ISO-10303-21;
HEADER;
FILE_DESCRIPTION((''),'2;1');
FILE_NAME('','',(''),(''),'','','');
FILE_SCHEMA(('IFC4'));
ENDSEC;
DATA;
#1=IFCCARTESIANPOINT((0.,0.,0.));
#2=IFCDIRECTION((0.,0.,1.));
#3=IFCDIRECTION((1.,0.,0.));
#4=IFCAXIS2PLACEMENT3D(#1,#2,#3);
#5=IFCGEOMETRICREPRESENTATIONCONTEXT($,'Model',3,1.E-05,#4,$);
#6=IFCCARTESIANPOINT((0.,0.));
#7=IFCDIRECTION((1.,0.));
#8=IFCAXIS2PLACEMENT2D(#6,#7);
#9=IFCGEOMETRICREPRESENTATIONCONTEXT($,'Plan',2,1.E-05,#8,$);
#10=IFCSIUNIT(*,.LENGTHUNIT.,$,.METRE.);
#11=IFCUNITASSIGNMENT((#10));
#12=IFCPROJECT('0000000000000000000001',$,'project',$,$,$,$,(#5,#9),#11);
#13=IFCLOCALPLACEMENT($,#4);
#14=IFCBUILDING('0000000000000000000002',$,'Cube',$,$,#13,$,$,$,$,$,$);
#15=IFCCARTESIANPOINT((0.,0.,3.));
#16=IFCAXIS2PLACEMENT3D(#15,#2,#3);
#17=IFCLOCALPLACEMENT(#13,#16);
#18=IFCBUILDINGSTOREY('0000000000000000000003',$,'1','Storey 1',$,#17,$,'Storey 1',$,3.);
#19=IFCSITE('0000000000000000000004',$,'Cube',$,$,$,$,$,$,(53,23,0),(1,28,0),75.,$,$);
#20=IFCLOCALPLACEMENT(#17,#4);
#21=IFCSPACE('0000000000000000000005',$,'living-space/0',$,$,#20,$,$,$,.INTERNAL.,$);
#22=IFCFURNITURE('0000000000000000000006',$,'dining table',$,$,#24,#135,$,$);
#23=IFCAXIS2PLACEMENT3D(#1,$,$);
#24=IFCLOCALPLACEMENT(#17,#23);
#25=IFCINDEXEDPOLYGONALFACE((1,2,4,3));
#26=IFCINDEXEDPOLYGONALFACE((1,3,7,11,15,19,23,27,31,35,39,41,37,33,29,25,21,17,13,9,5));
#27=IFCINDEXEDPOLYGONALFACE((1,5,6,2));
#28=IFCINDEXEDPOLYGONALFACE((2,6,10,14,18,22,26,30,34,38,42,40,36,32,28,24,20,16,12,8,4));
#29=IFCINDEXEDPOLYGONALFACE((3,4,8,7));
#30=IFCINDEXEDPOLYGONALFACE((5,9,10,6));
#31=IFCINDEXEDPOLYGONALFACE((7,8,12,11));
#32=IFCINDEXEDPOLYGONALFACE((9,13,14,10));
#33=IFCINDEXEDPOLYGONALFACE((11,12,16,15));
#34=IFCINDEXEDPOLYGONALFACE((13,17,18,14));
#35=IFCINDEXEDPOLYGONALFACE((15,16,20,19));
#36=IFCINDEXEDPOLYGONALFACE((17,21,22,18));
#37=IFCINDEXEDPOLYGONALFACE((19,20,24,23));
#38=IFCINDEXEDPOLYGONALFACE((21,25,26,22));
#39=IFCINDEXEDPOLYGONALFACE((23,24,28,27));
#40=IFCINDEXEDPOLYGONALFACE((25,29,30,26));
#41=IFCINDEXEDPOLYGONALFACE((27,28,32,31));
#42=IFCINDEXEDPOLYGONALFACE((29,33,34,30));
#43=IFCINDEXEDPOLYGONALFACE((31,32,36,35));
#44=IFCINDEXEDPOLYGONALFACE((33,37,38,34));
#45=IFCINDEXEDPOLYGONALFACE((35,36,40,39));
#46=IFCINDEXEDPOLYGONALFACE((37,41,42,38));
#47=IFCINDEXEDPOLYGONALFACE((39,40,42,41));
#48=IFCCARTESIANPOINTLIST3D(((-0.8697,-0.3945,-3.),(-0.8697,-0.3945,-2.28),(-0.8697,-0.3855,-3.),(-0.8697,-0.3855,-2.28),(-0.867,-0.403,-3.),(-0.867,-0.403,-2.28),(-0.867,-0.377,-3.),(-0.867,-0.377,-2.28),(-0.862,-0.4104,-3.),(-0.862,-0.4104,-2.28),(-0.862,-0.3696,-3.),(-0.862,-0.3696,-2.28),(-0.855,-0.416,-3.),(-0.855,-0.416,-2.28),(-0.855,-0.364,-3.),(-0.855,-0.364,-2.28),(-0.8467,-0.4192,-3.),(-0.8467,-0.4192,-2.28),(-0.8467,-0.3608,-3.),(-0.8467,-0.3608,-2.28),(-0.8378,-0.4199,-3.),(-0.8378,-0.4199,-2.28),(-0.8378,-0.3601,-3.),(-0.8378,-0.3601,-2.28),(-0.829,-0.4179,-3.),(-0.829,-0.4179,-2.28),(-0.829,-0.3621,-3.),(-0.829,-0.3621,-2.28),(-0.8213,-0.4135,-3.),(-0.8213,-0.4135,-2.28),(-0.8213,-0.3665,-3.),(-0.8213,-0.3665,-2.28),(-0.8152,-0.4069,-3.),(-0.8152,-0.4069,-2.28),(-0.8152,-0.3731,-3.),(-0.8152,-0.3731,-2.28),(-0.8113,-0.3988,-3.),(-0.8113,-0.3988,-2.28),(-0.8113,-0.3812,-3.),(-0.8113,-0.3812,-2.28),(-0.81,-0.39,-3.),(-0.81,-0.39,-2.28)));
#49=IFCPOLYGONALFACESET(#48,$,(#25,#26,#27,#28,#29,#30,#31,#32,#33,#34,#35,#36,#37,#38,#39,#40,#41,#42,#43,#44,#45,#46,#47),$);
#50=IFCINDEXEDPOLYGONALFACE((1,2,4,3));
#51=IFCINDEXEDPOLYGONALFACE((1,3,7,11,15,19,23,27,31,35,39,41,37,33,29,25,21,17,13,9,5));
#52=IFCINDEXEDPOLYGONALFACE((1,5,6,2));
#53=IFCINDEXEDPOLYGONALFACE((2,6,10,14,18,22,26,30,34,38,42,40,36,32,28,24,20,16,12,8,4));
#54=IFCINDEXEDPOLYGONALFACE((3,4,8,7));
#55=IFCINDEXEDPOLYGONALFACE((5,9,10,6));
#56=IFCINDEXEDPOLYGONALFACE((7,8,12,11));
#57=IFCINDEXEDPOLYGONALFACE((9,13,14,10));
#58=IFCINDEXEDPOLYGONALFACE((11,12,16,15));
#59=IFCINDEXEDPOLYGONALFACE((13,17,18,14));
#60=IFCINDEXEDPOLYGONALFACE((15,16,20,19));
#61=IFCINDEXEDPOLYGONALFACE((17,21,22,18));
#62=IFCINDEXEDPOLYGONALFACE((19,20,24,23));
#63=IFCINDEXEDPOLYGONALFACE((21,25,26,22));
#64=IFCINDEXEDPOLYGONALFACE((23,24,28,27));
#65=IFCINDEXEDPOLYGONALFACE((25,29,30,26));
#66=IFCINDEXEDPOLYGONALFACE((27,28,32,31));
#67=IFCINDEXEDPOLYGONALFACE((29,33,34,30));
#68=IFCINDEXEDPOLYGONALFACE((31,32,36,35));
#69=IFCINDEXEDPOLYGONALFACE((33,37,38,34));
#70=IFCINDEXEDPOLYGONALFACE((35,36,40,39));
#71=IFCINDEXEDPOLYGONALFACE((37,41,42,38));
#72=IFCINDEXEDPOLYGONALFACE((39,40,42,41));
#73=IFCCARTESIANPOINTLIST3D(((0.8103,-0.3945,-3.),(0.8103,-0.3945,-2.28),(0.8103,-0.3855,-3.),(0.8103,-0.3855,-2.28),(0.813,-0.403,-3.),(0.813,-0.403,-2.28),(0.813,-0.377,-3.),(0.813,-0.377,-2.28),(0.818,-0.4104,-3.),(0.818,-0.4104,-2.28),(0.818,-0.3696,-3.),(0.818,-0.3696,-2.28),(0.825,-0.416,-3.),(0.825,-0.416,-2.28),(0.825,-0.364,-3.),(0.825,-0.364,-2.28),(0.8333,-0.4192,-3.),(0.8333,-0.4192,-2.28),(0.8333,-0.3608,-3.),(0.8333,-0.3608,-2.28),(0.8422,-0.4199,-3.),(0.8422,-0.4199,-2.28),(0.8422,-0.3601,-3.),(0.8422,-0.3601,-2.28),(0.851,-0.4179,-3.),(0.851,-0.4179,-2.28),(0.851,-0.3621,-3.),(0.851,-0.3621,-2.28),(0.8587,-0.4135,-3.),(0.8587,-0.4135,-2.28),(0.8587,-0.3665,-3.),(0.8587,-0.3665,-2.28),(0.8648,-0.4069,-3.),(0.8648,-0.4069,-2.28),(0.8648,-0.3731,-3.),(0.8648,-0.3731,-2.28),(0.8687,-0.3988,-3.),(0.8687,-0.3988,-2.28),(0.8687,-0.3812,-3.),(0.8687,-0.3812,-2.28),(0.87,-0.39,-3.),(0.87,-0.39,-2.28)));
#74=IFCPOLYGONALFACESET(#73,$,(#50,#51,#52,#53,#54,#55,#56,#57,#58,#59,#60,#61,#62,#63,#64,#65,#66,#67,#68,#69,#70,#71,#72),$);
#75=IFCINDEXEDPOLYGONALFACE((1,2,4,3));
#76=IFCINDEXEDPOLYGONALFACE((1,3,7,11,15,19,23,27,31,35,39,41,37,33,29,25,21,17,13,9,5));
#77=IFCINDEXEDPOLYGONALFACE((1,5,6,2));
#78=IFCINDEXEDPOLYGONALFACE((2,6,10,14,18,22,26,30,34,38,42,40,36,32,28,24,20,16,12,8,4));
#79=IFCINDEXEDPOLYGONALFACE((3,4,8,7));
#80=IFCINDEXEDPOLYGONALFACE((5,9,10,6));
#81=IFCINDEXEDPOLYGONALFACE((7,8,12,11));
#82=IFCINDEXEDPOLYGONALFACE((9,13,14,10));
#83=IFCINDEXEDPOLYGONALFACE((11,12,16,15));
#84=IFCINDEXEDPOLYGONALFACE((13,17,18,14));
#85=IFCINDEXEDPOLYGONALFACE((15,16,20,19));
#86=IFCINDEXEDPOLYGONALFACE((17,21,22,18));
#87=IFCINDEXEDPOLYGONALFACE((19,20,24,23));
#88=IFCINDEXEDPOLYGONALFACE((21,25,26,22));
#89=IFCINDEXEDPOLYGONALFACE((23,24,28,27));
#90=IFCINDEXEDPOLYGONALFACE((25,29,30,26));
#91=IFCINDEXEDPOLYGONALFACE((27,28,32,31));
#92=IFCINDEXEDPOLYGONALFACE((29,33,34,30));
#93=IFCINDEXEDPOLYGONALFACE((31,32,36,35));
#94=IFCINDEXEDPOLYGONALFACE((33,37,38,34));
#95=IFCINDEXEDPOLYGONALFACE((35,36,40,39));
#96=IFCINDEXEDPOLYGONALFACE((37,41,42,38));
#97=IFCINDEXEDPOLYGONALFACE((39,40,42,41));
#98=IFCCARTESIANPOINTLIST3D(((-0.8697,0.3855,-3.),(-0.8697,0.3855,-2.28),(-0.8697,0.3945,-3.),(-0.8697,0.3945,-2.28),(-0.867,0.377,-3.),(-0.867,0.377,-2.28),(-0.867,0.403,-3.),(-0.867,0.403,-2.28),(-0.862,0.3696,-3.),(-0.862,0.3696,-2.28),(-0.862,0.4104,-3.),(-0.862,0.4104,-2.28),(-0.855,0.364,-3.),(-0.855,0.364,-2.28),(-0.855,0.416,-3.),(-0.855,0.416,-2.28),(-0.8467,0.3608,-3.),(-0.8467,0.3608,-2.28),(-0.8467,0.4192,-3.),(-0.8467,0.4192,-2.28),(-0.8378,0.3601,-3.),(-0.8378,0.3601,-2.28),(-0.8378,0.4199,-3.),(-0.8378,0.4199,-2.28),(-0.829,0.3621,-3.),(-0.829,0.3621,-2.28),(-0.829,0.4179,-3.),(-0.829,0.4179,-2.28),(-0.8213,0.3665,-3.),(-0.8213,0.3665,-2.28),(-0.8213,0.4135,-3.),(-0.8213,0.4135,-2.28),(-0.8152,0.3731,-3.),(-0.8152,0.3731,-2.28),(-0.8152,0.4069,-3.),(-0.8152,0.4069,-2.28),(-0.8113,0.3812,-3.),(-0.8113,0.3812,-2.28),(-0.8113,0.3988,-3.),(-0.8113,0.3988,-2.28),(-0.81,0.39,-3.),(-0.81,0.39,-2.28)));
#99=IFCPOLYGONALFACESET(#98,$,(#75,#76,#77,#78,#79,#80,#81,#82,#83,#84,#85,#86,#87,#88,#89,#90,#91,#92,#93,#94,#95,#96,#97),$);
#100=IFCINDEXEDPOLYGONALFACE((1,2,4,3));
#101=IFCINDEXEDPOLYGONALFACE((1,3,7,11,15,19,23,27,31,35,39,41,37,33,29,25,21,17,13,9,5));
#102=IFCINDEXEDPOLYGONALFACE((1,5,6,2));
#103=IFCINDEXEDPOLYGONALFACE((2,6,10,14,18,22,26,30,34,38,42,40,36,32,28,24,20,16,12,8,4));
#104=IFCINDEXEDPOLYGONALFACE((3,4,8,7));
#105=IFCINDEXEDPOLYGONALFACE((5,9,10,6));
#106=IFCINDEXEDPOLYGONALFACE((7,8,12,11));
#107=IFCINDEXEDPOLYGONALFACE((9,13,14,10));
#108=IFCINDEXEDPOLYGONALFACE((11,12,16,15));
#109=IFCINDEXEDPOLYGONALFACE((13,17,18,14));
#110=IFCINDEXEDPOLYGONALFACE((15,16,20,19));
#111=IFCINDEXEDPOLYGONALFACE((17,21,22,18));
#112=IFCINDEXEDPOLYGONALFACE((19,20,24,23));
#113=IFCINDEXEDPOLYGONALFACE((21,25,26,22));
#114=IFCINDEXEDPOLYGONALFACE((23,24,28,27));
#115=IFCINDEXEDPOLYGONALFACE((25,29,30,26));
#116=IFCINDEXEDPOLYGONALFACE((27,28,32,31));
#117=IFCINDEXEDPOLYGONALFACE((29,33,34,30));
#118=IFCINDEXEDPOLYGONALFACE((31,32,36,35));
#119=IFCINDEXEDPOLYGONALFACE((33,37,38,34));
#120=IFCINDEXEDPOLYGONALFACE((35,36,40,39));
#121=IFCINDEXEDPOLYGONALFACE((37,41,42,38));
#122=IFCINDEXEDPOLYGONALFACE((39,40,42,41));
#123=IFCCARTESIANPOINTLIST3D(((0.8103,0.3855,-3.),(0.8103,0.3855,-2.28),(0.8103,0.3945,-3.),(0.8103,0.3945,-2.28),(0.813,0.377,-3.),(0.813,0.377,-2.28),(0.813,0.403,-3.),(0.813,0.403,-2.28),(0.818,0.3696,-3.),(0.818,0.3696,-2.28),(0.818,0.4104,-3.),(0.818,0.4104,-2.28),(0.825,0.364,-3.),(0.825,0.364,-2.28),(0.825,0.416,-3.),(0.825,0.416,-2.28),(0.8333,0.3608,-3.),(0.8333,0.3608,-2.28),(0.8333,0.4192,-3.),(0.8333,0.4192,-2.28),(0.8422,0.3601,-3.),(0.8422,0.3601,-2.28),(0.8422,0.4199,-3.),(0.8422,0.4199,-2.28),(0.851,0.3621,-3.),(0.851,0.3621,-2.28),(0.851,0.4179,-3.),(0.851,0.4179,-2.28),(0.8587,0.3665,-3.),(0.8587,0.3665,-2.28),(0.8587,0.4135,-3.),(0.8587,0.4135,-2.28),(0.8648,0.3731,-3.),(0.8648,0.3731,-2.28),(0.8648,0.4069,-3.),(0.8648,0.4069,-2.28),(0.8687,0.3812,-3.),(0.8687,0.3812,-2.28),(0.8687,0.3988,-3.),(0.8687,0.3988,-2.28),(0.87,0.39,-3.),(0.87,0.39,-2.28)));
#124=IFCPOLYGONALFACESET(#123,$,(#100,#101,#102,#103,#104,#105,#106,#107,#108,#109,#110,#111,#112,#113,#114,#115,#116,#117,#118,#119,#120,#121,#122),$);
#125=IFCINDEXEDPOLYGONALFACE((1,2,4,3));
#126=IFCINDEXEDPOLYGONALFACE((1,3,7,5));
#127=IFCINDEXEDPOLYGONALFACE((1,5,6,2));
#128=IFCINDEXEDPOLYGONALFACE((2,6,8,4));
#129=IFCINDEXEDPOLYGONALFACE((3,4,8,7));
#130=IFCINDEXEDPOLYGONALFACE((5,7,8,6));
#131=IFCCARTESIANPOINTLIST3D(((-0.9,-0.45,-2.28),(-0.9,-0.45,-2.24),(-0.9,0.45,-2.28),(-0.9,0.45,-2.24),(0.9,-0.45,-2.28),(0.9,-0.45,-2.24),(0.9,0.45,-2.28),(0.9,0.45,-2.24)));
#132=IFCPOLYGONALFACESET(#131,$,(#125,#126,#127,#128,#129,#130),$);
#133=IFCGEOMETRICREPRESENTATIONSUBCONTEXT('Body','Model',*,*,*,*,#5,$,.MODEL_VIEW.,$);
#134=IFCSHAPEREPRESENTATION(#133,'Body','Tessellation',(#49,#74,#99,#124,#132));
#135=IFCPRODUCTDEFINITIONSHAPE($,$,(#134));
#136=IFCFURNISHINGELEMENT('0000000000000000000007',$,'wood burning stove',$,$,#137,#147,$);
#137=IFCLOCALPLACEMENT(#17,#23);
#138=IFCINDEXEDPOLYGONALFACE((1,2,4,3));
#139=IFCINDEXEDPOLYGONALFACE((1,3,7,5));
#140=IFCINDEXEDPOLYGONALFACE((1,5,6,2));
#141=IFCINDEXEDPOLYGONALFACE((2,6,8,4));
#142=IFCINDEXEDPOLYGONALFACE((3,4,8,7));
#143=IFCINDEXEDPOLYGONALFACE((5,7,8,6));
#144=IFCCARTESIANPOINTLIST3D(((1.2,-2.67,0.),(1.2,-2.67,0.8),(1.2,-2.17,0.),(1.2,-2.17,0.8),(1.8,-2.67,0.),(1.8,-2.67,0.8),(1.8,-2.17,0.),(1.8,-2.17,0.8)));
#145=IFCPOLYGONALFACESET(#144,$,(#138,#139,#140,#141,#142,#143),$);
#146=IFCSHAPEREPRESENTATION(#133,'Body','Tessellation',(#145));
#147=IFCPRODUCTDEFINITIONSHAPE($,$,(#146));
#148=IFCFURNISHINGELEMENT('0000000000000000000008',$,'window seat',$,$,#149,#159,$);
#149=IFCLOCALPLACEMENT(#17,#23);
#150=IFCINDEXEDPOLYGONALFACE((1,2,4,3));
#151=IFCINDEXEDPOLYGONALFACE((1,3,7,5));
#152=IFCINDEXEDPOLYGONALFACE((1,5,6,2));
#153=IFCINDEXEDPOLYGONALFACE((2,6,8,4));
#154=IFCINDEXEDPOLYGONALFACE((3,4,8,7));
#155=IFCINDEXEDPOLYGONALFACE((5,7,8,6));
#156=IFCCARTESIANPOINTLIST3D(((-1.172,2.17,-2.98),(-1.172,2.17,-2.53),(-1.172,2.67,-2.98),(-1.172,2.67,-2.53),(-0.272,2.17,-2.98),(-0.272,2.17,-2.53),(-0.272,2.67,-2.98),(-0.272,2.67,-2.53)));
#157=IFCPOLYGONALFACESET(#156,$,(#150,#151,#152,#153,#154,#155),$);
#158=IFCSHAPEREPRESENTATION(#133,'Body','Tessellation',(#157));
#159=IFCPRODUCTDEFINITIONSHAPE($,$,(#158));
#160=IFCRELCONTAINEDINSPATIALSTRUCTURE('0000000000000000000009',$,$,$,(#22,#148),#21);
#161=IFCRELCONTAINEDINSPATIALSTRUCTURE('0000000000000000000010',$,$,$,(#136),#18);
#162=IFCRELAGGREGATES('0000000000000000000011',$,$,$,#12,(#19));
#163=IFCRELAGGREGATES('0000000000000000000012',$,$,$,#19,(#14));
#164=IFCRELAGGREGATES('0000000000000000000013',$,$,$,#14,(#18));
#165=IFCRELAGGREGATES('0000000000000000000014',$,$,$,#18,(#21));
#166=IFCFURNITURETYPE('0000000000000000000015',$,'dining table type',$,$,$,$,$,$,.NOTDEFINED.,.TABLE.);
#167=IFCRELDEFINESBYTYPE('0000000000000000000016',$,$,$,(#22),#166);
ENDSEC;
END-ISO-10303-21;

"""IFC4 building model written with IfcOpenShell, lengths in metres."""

from ifc_helpers import new_model, entity, si_unit, frame, origin_with_axes, origin_2d_with_axis, place, context, subcontext, project, spatial, line, indexed_curve, outline, extrude, source, transform, mapped, type_object, type_shapes, element, save


model = new_model("IFC4")

# Units and contexts
model_context = context("Model", 3, precision=1e-05, world=origin_with_axes())
plan_context = context("Plan", 2, precision=1e-05, world=origin_2d_with_axis())
body_context_1 = subcontext(model_context, "Body", "Model", "MODEL_VIEW")
ifc_project = project(units=[si_unit("LENGTHUNIT", "METRE")], contexts=[model_context, plan_context])

# Site, building, storey
site = spatial("IfcSite", under=ifc_project, Name="Cube", RefLatitude=(53, 23, 0), RefLongitude=(1, 28, 0), RefElevation=75.0)
building_placement = place(None, origin_with_axes())
building = spatial("IfcBuilding", under=site, at=building_placement, Name="Cube")
storey_placement = place(building_placement, frame((0.0, 0.0, 3.0), z_axis=(0.0, 0.0, 1.0), x_axis=(1.0, 0.0, 0.0)))
storey = spatial("IfcBuildingStorey", under=building, at=storey_placement, Name="1", Description="Storey 1", LongName="Storey 1", Elevation=3.0)

# Shared definitions
space_placement = place(storey_placement, origin_with_axes())
space = spatial("IfcSpace", under=storey, at=space_placement, Name="living-space/0", PredefinedType="INTERNAL")

# Furniture
furniture_type_1 = type_object("IfcFurnitureType", Name="dining table type", AssemblyPlace="NOTDEFINED", PredefinedType="TABLE")
shared_circle = entity("IfcCircle", entity("IfcAxis2Placement2D", entity("IfcCartesianPoint", [0.0, 0.0])), 0.03)
shared_shape_1 = source(origin_with_axes(), body_context_1, "Body", "SweptSolid", [
    entity("IfcExtrudedAreaSolid", entity("IfcArbitraryClosedProfileDef", "AREA", None, shared_circle), entity("IfcAxis2Placement3D", entity("IfcCartesianPoint", [-0.84, -0.39, 0.0]), entity("IfcDirection", [0.0, 0.0, 1.0]), entity("IfcDirection", [1.0, 0.0, 0.0])), entity("IfcDirection", [0.0, 0.0, 1.0]), 0.72),
    entity("IfcExtrudedAreaSolid", entity("IfcArbitraryClosedProfileDef", "AREA", None, shared_circle), entity("IfcAxis2Placement3D", entity("IfcCartesianPoint", [0.84, -0.39, 0.0]), entity("IfcDirection", [0.0, 0.0, 1.0]), entity("IfcDirection", [1.0, 0.0, 0.0])), entity("IfcDirection", [0.0, 0.0, 1.0]), 0.72),
    entity("IfcExtrudedAreaSolid", entity("IfcArbitraryClosedProfileDef", "AREA", None, shared_circle), entity("IfcAxis2Placement3D", entity("IfcCartesianPoint", [-0.84, 0.39, 0.0]), entity("IfcDirection", [0.0, 0.0, 1.0]), entity("IfcDirection", [1.0, 0.0, 0.0])), entity("IfcDirection", [0.0, 0.0, 1.0]), 0.72),
    entity("IfcExtrudedAreaSolid", entity("IfcArbitraryClosedProfileDef", "AREA", None, shared_circle), entity("IfcAxis2Placement3D", entity("IfcCartesianPoint", [0.84, 0.39, 0.0]), entity("IfcDirection", [0.0, 0.0, 1.0]), entity("IfcDirection", [1.0, 0.0, 0.0])), entity("IfcDirection", [0.0, 0.0, 1.0]), 0.72),
    extrude(outline(indexed_curve([(-0.9, -0.45), (0.9, -0.45), (0.9, 0.45), (-0.9, 0.45)], segments=[line(1, 2, 3, 4, 1)])), frame((0.0, 0.0, 0.72), z_axis=(0.0, 0.0, 1.0), x_axis=(1.0, 0.0, 0.0)), (0.0, 0.0, 1.0), 0.04),
])
type_shapes(furniture_type_1, [shared_shape_1])
furniture_placement = place(space_placement, frame((0.0, 0.0, -3.0), z_axis=(0.0, 0.0, 1.0), x_axis=(1.0, 0.0, 0.0)))
element("IfcFurniture", 1, at=furniture_placement, inside=space, type_object=furniture_type_1, Name="dining table", context=body_context_1, shape_type="MappedRepresentation", body=[
    mapped(shared_shape_1, transform((0.0, 0.0, 0.0), x_axis=(1.0, 0.0, 0.0), y_axis=(0.0, 1.0, 0.0), z_axis=(0.0, 0.0, 1.0), scale=1.0)),
])

# Furnishing elements
furnishing_1_placement = place(storey_placement, frame((1.2, -2.67, 0.0), z_axis=(0.0, 0.0, 1.0), x_axis=(1.0, 0.0, 0.0)))
element("IfcFurnishingElement", 2, at=furnishing_1_placement, inside=storey, Name="wood burning stove", context=body_context_1, shape_type="SweptSolid", body=[
    extrude(outline(indexed_curve([(0.0, 0.0), (0.6, 0.0), (0.6, 0.5), (0.0, 0.5)])), None, (0.0, 0.0, 1.0), 0.8),
])
furnishing_2_placement = place(space_placement, frame((-1.172, 2.17, -2.98), z_axis=(0.0, 0.0, 1.0), x_axis=(1.0, 0.0, 0.0)))
element("IfcFurnishingElement", 3, at=furnishing_2_placement, inside=space, Name="window seat", context=body_context_1, shape_type="SweptSolid", body=[
    extrude(outline(indexed_curve([(0.0, 0.0), (0.9, 0.0), (0.9, 0.5), (0.0, 0.5)])), None, (0.0, 0.0, 1.0), 0.45),
])

save(model, "model.ifc")
